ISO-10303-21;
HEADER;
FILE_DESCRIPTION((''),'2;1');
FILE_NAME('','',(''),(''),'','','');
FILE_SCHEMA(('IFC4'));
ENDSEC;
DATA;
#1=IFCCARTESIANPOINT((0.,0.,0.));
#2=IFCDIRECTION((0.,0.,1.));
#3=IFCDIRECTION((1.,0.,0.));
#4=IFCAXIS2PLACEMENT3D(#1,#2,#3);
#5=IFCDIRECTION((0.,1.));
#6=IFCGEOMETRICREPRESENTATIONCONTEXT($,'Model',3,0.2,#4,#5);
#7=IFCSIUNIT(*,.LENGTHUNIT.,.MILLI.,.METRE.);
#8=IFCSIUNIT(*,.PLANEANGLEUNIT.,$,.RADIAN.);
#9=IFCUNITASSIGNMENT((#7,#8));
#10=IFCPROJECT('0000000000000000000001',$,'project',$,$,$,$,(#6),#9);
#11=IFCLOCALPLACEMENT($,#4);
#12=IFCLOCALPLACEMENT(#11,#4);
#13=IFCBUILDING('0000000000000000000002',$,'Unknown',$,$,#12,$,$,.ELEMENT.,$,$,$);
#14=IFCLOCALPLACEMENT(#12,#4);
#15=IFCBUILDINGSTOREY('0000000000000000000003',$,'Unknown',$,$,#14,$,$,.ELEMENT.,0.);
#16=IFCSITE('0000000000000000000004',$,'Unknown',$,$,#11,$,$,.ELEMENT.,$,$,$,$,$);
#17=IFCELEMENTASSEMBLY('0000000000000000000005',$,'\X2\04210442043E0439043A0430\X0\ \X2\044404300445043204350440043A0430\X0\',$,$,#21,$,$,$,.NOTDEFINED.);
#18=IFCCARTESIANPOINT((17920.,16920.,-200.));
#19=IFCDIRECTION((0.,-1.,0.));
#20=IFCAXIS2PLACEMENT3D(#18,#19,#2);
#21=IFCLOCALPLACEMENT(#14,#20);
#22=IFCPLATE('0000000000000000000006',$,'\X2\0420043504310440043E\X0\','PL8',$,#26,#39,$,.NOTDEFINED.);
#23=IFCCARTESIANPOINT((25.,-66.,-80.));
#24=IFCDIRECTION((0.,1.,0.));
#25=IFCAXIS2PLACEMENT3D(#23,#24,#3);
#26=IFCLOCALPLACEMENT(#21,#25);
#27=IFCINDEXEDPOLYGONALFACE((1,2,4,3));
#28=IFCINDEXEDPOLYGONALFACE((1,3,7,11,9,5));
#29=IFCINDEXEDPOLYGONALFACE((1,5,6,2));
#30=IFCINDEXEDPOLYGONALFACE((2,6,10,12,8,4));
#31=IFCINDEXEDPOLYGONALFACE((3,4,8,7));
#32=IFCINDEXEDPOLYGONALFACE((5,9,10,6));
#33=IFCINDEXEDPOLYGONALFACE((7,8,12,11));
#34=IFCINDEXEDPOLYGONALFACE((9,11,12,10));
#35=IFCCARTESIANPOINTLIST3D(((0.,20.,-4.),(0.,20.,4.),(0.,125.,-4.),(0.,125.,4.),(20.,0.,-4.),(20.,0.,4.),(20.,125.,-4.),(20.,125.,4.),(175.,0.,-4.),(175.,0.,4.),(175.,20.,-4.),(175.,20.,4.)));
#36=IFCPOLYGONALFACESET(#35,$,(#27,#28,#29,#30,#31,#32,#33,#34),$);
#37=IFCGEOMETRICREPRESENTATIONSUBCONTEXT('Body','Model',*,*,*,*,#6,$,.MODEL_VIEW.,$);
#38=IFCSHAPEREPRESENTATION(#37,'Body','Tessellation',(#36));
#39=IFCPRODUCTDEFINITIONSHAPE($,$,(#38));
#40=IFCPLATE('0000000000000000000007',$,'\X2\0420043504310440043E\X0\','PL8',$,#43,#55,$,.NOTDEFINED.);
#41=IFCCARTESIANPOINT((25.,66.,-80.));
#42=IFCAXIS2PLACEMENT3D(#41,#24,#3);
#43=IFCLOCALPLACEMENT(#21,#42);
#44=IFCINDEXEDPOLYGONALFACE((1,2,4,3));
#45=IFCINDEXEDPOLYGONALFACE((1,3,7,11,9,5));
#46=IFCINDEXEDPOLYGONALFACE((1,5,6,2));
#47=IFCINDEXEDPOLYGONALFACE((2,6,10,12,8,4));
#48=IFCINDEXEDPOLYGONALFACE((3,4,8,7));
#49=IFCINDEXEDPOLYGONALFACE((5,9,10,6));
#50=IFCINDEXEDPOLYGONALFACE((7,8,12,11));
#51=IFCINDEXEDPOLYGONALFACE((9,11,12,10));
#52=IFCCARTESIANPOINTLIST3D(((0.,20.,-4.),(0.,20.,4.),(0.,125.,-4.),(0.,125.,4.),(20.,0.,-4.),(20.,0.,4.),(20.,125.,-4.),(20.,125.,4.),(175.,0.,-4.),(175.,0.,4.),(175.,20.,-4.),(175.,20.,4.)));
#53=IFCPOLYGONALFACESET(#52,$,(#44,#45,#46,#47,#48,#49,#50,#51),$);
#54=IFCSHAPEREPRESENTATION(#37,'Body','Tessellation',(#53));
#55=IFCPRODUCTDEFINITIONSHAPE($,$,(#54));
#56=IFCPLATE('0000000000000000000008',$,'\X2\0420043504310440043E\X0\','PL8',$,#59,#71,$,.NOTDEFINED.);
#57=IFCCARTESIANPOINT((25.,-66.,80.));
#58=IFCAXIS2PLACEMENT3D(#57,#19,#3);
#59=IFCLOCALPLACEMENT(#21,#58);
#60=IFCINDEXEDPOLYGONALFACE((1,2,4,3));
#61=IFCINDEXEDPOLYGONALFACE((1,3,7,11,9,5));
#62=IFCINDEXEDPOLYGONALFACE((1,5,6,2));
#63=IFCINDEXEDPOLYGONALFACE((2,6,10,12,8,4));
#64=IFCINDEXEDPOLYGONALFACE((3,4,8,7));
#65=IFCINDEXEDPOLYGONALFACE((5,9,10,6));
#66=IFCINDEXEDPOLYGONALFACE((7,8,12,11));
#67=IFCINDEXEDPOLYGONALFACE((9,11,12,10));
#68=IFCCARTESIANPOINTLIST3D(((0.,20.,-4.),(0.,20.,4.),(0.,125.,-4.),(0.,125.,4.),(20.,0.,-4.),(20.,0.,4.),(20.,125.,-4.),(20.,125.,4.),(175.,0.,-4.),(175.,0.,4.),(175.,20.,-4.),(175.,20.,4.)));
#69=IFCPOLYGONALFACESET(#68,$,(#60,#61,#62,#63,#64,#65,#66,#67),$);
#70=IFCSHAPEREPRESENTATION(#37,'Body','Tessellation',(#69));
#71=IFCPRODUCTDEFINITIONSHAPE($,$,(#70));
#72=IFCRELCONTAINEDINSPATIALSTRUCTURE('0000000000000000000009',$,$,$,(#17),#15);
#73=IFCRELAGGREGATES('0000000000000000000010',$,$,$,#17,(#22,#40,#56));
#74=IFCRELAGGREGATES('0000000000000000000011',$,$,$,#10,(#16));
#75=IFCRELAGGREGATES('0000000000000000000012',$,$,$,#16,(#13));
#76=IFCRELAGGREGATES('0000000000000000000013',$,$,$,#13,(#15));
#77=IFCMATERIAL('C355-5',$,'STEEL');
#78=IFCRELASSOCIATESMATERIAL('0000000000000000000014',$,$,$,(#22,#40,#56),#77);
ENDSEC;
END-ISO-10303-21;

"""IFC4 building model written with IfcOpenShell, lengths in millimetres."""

from ifc_helpers import new_model, si_unit, direction, frame, origin_with_axes, place, context, subcontext, project, spatial, line, indexed_curve, outline, extrude, material, element, aggregate, save


model = new_model("IFC4")

# Units and contexts
model_context = context("Model", 3, precision=0.2, world=origin_with_axes(), true_north=direction((0.0, 1.0)))
body_context = subcontext(model_context, "Body", "Model", "MODEL_VIEW")
ifc_project = project(units=[si_unit("LENGTHUNIT", "METRE", prefix="MILLI"), si_unit("PLANEANGLEUNIT", "RADIAN")], contexts=[model_context])

# Site, building, storey
site_placement = place(None, origin_with_axes())
site = spatial("IfcSite", under=ifc_project, at=site_placement, Name="Unknown", CompositionType="ELEMENT")
building_placement = place(site_placement, origin_with_axes())
building = spatial("IfcBuilding", under=site, at=building_placement, Name="Unknown", CompositionType="ELEMENT")
storey_placement = place(building_placement, origin_with_axes())
storey = spatial("IfcBuildingStorey", under=building, at=storey_placement, Name="Unknown", CompositionType="ELEMENT", Elevation=0.0)

# Shared definitions
ifc_material_1 = material(Name="C355-5", Category="STEEL")

# Element assembly
assembly_1_placement = place(storey_placement, frame((17920.0, 16920.0, -200.0), z_axis=(0.0, -1.0, 0.0), x_axis=(0.0, 0.0, 1.0)))
assembly_1 = element("IfcElementAssembly", 1, at=assembly_1_placement, inside=storey, Name="Стойка фахверка", PredefinedType="NOTDEFINED")

# Plates
plate_1_placement = place(assembly_1_placement, frame((25.0, -66.0, -80.0), z_axis=(0.0, 1.0, 0.0), x_axis=(1.0, 0.0, 0.0)))
plate_1 = element("IfcPlate", 2, at=plate_1_placement, material=ifc_material_1, Name="Ребро", Description="PL8", PredefinedType="NOTDEFINED", context=body_context, shape_type="SolidModel", body=[
    extrude(outline(indexed_curve([(0.0, 20.0), (20.0, 0.0), (175.0, 0.0), (175.0, 20.0), (20.0, 125.0), (0.0, 125.0)], segments=[line(1, 2, 3, 4, 5, 6, 1)])), frame((0.0, 0.0, 4.0), z_axis=(0.0, 0.0, 1.0), x_axis=(1.0, 0.0, 0.0)), (0.0, 0.0, -1.0), 8.0),
])
plate_2_placement = place(assembly_1_placement, frame((25.0, 66.0, -80.0), z_axis=(0.0, 1.0, 0.0), x_axis=(1.0, 0.0, 0.0)))
plate_2 = element("IfcPlate", 3, at=plate_2_placement, material=ifc_material_1, Name="Ребро", Description="PL8", PredefinedType="NOTDEFINED", context=body_context, shape_type="SolidModel", body=[
    extrude(outline(indexed_curve([(0.0, 20.0), (20.0, 0.0), (175.0, 0.0), (175.0, 20.0), (20.0, 125.0), (0.0, 125.0)], segments=[line(1, 2, 3, 4, 5, 6, 1)])), frame((0.0, 0.0, 4.0), z_axis=(0.0, 0.0, 1.0), x_axis=(1.0, 0.0, 0.0)), (0.0, 0.0, -1.0), 8.0),
])
plate_3_placement = place(assembly_1_placement, frame((25.0, -66.0, 80.0), z_axis=(0.0, -1.0, 0.0), x_axis=(1.0, 0.0, 0.0)))
plate_3 = element("IfcPlate", 4, at=plate_3_placement, material=ifc_material_1, Name="Ребро", Description="PL8", PredefinedType="NOTDEFINED", context=body_context, shape_type="SolidModel", body=[
    extrude(outline(indexed_curve([(0.0, 20.0), (20.0, 0.0), (175.0, 0.0), (175.0, 20.0), (20.0, 125.0), (0.0, 125.0)], segments=[line(1, 2, 3, 4, 5, 6, 1)])), frame((0.0, 0.0, 4.0), z_axis=(0.0, 0.0, 1.0), x_axis=(1.0, 0.0, 0.0)), (0.0, 0.0, -1.0), 8.0),
])
aggregate(assembly_1, [plate_1, plate_2, plate_3])

save(model, "model.ifc")
